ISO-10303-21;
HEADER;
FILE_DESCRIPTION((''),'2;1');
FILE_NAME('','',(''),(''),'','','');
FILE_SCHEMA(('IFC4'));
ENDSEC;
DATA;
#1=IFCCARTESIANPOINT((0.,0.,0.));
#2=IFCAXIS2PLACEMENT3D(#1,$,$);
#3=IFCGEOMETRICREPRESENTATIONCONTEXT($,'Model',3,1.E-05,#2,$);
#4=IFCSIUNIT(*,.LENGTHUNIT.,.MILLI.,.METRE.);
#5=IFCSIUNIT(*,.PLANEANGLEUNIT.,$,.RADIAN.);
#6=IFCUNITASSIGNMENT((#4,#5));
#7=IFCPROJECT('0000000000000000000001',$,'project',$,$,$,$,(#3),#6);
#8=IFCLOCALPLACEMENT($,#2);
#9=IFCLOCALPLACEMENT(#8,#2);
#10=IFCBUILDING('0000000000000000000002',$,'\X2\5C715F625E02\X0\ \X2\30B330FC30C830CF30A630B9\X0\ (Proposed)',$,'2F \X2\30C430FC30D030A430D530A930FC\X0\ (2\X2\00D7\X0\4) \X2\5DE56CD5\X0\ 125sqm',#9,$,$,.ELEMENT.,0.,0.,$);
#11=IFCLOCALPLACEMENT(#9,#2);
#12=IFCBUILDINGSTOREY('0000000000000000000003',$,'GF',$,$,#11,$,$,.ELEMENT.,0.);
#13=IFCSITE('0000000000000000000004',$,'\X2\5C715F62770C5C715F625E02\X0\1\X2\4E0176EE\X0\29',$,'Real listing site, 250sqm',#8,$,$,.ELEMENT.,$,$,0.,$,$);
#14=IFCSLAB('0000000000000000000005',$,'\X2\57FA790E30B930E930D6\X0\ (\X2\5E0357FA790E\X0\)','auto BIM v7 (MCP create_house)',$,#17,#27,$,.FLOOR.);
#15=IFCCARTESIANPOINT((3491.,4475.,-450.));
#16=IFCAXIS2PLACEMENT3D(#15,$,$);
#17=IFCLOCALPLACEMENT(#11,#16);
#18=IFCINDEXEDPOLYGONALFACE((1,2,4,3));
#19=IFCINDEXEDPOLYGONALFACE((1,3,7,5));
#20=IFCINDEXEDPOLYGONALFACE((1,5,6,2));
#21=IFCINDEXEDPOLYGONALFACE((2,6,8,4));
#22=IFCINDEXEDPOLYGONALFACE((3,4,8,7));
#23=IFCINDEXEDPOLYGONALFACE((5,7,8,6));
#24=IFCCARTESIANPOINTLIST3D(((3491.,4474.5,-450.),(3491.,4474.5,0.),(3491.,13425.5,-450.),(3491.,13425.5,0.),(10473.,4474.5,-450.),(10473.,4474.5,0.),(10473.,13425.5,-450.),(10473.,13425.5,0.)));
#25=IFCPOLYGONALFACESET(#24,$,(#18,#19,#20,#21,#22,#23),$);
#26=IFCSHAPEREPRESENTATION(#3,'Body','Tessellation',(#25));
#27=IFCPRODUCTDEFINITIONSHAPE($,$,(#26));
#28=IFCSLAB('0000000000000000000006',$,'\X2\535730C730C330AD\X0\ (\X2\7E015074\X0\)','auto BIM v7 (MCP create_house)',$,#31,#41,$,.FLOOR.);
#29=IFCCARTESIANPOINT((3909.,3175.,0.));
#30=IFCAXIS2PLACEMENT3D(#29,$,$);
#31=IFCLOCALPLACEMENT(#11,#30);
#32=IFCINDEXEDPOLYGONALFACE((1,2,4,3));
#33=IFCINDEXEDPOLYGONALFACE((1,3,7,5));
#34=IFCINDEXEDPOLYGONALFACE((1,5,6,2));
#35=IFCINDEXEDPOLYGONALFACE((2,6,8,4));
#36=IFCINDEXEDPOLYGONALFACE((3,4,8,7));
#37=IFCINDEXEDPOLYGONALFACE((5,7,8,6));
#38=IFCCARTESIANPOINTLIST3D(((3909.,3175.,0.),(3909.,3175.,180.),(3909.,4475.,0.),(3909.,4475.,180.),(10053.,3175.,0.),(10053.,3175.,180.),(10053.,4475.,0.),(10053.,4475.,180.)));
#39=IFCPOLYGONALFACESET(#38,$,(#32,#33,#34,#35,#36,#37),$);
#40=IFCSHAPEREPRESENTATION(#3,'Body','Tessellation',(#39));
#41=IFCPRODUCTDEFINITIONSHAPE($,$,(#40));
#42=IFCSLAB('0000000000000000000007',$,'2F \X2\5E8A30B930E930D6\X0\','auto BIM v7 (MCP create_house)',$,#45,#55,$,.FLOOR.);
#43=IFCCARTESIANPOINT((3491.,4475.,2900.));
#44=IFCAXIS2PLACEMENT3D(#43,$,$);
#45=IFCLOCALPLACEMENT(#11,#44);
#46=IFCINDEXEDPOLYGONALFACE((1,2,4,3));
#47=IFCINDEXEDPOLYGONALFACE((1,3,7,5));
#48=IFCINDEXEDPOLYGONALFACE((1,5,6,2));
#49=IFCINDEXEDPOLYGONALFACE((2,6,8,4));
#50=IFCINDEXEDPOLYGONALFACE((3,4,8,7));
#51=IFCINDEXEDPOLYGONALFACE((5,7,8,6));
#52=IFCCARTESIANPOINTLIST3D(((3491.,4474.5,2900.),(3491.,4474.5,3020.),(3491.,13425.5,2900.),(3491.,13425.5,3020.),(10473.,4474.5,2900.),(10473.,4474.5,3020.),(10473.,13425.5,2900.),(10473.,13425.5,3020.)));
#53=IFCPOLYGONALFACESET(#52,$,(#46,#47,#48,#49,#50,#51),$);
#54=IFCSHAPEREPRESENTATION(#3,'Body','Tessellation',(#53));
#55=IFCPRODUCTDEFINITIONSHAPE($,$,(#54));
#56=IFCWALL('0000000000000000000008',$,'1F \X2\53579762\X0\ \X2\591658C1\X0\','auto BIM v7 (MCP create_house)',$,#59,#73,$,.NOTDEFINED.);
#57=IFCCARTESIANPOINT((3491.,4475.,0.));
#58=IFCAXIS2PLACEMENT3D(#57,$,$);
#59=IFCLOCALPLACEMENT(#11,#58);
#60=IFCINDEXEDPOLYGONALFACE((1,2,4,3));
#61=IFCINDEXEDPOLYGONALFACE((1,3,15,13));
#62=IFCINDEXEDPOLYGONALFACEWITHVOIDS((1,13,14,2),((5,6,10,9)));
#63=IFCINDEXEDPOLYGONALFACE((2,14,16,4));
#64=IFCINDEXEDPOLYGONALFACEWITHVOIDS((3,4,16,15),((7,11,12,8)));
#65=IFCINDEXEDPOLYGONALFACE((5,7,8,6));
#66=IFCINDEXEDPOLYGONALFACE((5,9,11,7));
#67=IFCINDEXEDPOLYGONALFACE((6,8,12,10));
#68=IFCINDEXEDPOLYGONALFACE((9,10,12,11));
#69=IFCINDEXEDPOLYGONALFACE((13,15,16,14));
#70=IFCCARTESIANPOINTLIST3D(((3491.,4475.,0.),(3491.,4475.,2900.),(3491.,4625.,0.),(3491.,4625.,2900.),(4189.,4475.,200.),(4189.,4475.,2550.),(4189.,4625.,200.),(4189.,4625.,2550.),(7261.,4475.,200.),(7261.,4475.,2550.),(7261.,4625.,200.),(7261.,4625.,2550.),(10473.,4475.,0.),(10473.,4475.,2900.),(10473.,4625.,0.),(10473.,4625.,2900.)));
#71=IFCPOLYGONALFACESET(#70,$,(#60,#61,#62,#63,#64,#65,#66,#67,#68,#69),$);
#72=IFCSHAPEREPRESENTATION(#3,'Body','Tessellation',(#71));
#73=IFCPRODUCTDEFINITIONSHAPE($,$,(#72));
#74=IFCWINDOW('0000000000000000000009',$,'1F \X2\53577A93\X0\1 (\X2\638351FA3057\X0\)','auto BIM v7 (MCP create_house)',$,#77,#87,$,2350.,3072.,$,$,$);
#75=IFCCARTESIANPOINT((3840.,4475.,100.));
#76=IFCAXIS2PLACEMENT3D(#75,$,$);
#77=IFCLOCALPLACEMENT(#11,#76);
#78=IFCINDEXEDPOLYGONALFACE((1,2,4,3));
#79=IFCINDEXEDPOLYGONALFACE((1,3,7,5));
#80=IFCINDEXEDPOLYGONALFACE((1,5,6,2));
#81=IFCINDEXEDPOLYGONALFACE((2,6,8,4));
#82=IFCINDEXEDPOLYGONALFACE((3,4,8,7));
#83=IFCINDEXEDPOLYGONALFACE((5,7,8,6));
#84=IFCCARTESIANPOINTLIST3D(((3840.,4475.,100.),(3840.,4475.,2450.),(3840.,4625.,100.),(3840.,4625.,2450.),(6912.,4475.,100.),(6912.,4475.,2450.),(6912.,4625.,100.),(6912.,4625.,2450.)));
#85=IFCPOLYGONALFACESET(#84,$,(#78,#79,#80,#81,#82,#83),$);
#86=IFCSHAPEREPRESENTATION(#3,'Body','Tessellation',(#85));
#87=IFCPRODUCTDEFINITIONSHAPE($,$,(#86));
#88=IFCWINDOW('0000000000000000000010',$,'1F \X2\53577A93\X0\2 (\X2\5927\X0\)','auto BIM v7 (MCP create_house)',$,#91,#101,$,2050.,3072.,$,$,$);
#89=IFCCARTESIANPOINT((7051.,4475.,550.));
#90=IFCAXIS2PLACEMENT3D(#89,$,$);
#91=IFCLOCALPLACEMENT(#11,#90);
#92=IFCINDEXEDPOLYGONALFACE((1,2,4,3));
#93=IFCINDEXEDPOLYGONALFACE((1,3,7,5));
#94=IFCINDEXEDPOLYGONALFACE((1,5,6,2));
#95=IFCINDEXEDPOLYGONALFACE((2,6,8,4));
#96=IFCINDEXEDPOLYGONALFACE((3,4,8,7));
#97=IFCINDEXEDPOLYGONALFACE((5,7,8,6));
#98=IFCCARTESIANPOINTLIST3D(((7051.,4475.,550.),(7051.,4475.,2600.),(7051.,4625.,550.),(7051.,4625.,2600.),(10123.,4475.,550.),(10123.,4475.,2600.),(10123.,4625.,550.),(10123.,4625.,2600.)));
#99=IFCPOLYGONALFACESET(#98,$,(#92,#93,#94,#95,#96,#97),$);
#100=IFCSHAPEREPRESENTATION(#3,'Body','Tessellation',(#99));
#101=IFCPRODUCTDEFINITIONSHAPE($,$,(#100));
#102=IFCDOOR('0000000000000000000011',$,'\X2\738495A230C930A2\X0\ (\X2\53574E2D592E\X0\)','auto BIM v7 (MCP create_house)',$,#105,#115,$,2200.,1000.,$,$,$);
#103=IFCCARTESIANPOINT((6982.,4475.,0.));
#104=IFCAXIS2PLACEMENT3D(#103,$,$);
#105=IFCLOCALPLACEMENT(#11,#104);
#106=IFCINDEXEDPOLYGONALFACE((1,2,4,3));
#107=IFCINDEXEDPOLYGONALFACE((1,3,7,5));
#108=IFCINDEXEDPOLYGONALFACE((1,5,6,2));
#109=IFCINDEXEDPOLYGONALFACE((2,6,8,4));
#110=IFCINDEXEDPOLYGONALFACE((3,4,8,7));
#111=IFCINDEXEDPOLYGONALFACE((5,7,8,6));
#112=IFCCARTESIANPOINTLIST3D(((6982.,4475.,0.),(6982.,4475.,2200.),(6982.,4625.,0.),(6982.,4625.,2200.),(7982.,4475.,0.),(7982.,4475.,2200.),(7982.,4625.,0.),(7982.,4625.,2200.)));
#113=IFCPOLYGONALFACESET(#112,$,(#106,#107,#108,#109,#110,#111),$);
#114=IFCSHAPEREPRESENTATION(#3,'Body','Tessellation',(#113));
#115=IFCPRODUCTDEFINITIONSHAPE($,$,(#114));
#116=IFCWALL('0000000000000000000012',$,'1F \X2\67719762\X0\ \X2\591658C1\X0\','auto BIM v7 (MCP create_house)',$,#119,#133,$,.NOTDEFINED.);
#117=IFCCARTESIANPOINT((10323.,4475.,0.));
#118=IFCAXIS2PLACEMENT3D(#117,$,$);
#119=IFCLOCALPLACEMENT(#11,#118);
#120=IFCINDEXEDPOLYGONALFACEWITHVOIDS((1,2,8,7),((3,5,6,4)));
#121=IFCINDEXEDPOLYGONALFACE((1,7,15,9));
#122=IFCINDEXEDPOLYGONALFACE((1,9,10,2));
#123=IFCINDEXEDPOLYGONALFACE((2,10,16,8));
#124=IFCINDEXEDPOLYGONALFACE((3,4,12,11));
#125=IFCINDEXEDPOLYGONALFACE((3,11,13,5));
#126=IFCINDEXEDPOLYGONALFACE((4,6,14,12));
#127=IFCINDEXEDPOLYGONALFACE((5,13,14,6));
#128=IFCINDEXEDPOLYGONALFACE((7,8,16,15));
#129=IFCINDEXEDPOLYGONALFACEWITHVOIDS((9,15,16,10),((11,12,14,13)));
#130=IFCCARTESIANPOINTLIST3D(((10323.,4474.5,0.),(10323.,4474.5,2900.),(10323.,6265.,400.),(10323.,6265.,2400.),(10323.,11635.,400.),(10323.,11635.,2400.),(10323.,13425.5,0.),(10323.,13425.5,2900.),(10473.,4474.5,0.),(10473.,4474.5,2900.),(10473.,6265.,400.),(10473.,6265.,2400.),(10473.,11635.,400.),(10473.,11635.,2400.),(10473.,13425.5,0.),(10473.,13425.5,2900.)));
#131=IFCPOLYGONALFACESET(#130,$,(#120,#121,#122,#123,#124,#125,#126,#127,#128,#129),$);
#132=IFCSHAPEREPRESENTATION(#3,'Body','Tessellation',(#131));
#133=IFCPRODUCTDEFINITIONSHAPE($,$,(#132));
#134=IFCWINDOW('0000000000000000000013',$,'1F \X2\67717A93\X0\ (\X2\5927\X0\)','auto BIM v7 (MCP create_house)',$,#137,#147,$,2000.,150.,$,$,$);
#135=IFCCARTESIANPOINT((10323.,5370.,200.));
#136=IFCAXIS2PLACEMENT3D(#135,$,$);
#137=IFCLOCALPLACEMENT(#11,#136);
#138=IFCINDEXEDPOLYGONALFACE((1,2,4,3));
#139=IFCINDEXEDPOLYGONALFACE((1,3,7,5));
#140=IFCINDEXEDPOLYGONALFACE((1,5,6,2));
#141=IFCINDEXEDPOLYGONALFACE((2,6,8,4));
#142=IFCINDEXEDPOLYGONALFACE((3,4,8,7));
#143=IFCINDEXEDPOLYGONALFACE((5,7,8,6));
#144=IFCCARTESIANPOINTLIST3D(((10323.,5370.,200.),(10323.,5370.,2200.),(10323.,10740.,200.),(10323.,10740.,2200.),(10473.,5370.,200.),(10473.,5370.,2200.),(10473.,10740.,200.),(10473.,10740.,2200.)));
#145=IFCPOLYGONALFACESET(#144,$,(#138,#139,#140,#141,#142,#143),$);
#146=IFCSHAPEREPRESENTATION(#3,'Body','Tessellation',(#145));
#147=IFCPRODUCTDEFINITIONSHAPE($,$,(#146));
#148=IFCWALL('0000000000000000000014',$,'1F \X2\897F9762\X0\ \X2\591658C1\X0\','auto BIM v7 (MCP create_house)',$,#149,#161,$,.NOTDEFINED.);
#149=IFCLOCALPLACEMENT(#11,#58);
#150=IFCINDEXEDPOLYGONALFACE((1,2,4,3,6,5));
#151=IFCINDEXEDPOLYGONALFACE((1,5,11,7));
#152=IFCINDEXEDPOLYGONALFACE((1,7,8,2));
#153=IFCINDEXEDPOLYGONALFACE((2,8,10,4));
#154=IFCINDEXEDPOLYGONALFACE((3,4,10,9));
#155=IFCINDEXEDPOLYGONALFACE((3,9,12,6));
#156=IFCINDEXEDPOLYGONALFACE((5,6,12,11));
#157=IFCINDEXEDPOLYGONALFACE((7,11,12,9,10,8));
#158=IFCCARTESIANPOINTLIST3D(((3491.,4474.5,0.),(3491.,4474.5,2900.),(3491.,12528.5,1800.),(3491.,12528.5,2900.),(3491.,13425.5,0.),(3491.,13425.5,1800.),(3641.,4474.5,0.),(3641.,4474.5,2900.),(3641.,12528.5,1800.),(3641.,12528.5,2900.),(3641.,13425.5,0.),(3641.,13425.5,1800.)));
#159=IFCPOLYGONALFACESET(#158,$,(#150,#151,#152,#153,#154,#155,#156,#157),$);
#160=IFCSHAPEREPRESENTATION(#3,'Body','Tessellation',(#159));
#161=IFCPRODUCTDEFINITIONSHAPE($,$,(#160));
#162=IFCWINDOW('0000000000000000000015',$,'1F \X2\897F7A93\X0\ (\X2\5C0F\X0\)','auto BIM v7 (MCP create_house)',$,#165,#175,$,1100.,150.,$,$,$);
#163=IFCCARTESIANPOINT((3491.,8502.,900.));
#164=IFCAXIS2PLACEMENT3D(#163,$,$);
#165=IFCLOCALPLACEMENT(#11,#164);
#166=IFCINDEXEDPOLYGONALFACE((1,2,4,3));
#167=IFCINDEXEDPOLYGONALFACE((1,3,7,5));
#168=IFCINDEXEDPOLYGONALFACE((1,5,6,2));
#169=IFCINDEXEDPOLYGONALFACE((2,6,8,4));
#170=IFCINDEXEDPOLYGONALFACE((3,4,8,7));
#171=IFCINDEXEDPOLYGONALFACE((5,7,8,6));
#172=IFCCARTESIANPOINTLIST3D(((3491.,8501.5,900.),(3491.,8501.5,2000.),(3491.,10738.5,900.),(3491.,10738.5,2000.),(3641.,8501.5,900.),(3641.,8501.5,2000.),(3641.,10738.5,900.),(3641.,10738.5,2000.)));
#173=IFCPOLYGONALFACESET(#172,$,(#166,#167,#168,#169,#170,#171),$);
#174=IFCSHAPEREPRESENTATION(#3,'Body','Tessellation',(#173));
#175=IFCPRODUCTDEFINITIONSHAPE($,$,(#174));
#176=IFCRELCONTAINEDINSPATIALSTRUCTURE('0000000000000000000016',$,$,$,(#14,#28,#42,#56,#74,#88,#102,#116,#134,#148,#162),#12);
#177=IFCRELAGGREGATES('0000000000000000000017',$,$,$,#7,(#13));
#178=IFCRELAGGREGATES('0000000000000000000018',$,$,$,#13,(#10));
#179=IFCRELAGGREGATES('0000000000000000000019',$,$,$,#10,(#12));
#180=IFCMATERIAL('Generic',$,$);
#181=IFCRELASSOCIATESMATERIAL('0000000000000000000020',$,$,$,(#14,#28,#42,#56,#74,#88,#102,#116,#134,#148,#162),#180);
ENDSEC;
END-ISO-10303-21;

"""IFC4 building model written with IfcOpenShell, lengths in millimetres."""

from ifc_helpers import new_model, si_unit, frame, frame_2d, origin, place, context, project, spatial, rectangle, extrude, material, element, fill, save


model = new_model("IFC4")

# Units and contexts
model_context = context("Model", 3, precision=1e-05, world=origin())
ifc_project = project(units=[si_unit("LENGTHUNIT", "METRE", prefix="MILLI"), si_unit("PLANEANGLEUNIT", "RADIAN")], contexts=[model_context])

# Site, building, storey
site_placement = place(None, origin())
site = spatial("IfcSite", under=ifc_project, at=site_placement, Name="山形県山形市1丁目29", ObjectType="Real listing site, 250sqm", CompositionType="ELEMENT", RefElevation=0.0)
building_placement = place(site_placement, origin())
building = spatial("IfcBuilding", under=site, at=building_placement, Name="山形市 コートハウス (Proposed)", ObjectType="2F ツーバイフォー (2×4) 工法 125sqm", CompositionType="ELEMENT", ElevationOfRefHeight=0.0, ElevationOfTerrain=0.0)
storey_placement = place(building_placement, origin())
storey = spatial("IfcBuildingStorey", under=building, at=storey_placement, Name="GF", CompositionType="ELEMENT", Elevation=0.0)

# Slabs
ifc_material = material(Name="Generic")
slab_1_placement = place(storey_placement, frame((3491.0, 4475.0, -450.0)))
element("IfcSlab", 1, at=slab_1_placement, inside=storey, material=ifc_material, Name="基礎スラブ (布基礎)", Description="auto BIM v7 (MCP create_house)", PredefinedType="FLOOR", context=model_context, shape_type="SweptSolid", body=[
    extrude(rectangle(XDim=6982.0, YDim=8951.0, at=frame_2d((3491.0, 4475.0))), frame((3491.0, 4475.0, -450.0)), (0.0, 0.0, 1.0), 450.0),
])
slab_2_placement = place(storey_placement, frame((3909.0, 3175.0, 0.0)))
element("IfcSlab", 2, at=slab_2_placement, inside=storey, material=ifc_material, Name="南デッキ (縁側)", Description="auto BIM v7 (MCP create_house)", PredefinedType="FLOOR", context=model_context, shape_type="SweptSolid", body=[
    extrude(rectangle(XDim=6144.0, YDim=1300.0, at=frame_2d((3072.0, 650.0))), frame((3909.0, 3175.0, 0.0)), (0.0, 0.0, 1.0), 180.0),
])
slab_3_placement = place(storey_placement, frame((3491.0, 4475.0, 2900.0)))
element("IfcSlab", 3, at=slab_3_placement, inside=storey, material=ifc_material, Name="2F 床スラブ", Description="auto BIM v7 (MCP create_house)", PredefinedType="FLOOR", context=model_context, shape_type="SweptSolid", body=[
    extrude(rectangle(XDim=6982.0, YDim=8951.0, at=frame_2d((3491.0, 4475.0))), frame((3491.0, 4475.0, 2900.0)), (0.0, 0.0, 1.0), 120.0),
])

# Wall, openings, windows, door
wall_1_placement = place(storey_placement, frame((3491.0, 4475.0, 0.0)))
wall_1 = element("IfcWall", 4, at=wall_1_placement, inside=storey, material=ifc_material, Name="1F 南面 外壁", Description="auto BIM v7 (MCP create_house)", PredefinedType="NOTDEFINED", context=model_context, shape_type="SweptSolid", body=[
    extrude(rectangle(XDim=6982.0, YDim=150.0, at=frame_2d((3491.0, 75.0))), frame((3491.0, 4475.0, 0.0)), (0.0, 0.0, 1.0), 2900.0),
])
opening_1_placement = place(storey_placement, frame((3840.0, 4475.0, 100.0)))
opening_1 = element("IfcOpeningElement", 5, at=opening_1_placement, cuts=wall_1, PredefinedType="NOTDEFINED", context=model_context, shape_type="SweptSolid", body=[
    extrude(rectangle(XDim=3072.0, YDim=150.0, at=frame_2d((1536.0, 75.0))), frame((3840.0, 4475.0, 100.0)), (0.0, 0.0, 1.0), 2350.0),
])
opening_2_placement = place(storey_placement, frame((7051.0, 4475.0, 550.0)))
opening_2 = element("IfcOpeningElement", 6, at=opening_2_placement, cuts=wall_1, PredefinedType="NOTDEFINED", context=model_context, shape_type="SweptSolid", body=[
    extrude(rectangle(XDim=3072.0, YDim=150.0, at=frame_2d((1536.0, 75.0))), frame((7051.0, 4475.0, 550.0)), (0.0, 0.0, 1.0), 2050.0),
])
opening_3_placement = place(storey_placement, frame((6982.0, 4475.0, 0.0)))
opening_3 = element("IfcOpeningElement", 7, at=opening_3_placement, cuts=wall_1, PredefinedType="NOTDEFINED", context=model_context, shape_type="SweptSolid", body=[
    extrude(rectangle(XDim=1000.0, YDim=150.0, at=frame_2d((500.0, 75.0))), frame((6982.0, 4475.0, 0.0)), (0.0, 0.0, 1.0), 2200.0),
])
window_1_placement = place(storey_placement, frame((3840.0, 4475.0, 100.0)))
window_1 = element("IfcWindow", 8, at=window_1_placement, inside=storey, material=ifc_material, Name="1F 南窓1 (掃出し)", Description="auto BIM v7 (MCP create_house)", OverallHeight=2350.0, OverallWidth=3072.0, context=model_context, shape_type="SweptSolid", body=[
    extrude(rectangle(XDim=3072.0, YDim=150.0, at=frame_2d((1536.0, 75.0))), frame((3840.0, 4475.0, 100.0)), (0.0, 0.0, 1.0), 2350.0),
])
fill(opening_1, window_1)
window_2_placement = place(storey_placement, frame((7051.0, 4475.0, 550.0)))
window_2 = element("IfcWindow", 9, at=window_2_placement, inside=storey, material=ifc_material, Name="1F 南窓2 (大)", Description="auto BIM v7 (MCP create_house)", OverallHeight=2050.0, OverallWidth=3072.0, context=model_context, shape_type="SweptSolid", body=[
    extrude(rectangle(XDim=3072.0, YDim=150.0, at=frame_2d((1536.0, 75.0))), frame((7051.0, 4475.0, 550.0)), (0.0, 0.0, 1.0), 2050.0),
])
fill(opening_2, window_2)
door_placement = place(storey_placement, frame((6982.0, 4475.0, 0.0)))
door = element("IfcDoor", 10, at=door_placement, inside=storey, material=ifc_material, Name="玄関ドア (南中央)", Description="auto BIM v7 (MCP create_house)", OverallHeight=2200.0, OverallWidth=1000.0, context=model_context, shape_type="SweptSolid", body=[
    extrude(rectangle(XDim=1000.0, YDim=150.0, at=frame_2d((500.0, 75.0))), frame((6982.0, 4475.0, 0.0)), (0.0, 0.0, 1.0), 2200.0),
])
fill(opening_3, door)

# Walls, openings, windows
wall_2_placement = place(storey_placement, frame((10323.0, 4475.0, 0.0)))
wall_2 = element("IfcWall", 11, at=wall_2_placement, inside=storey, material=ifc_material, Name="1F 東面 外壁", Description="auto BIM v7 (MCP create_house)", PredefinedType="NOTDEFINED", context=model_context, shape_type="SweptSolid", body=[
    extrude(rectangle(XDim=150.0, YDim=8951.0, at=frame_2d((75.0, 4475.0))), frame((10323.0, 4475.0, 0.0)), (0.0, 0.0, 1.0), 2900.0),
])
opening_4_placement = place(storey_placement, frame((10323.0, 5370.0, 200.0)))
opening_4 = element("IfcOpeningElement", 12, at=opening_4_placement, cuts=wall_2, PredefinedType="NOTDEFINED", context=model_context, shape_type="SweptSolid", body=[
    extrude(rectangle(XDim=150.0, YDim=5370.0, at=frame_2d((75.0, 2685.0))), frame((10323.0, 5370.0, 200.0)), (0.0, 0.0, 1.0), 2000.0),
])
window_3_placement = place(storey_placement, frame((10323.0, 5370.0, 200.0)))
window_3 = element("IfcWindow", 13, at=window_3_placement, inside=storey, material=ifc_material, Name="1F 東窓 (大)", Description="auto BIM v7 (MCP create_house)", OverallHeight=2000.0, OverallWidth=150.0, context=model_context, shape_type="SweptSolid", body=[
    extrude(rectangle(XDim=150.0, YDim=5370.0, at=frame_2d((75.0, 2685.0))), frame((10323.0, 5370.0, 200.0)), (0.0, 0.0, 1.0), 2000.0),
])
fill(opening_4, window_3)
wall_3_placement = place(storey_placement, frame((3491.0, 4475.0, 0.0)))
wall_3 = element("IfcWall", 14, at=wall_3_placement, inside=storey, material=ifc_material, Name="1F 西面 外壁", Description="auto BIM v7 (MCP create_house)", PredefinedType="NOTDEFINED", context=model_context, shape_type="SweptSolid", body=[
    extrude(rectangle(XDim=150.0, YDim=8951.0, at=frame_2d((75.0, 4475.0))), frame((3491.0, 4475.0, 0.0)), (0.0, 0.0, 1.0), 2900.0),
])
opening_5_placement = place(storey_placement, frame((3491.0, 8502.0, 900.0)))
opening_5 = element("IfcOpeningElement", 15, at=opening_5_placement, cuts=wall_3, PredefinedType="NOTDEFINED", context=model_context, shape_type="SweptSolid", body=[
    extrude(rectangle(XDim=150.0, YDim=2237.0, at=frame_2d((75.0, 1118.0))), frame((3491.0, 8502.0, 900.0)), (0.0, 0.0, 1.0), 1100.0),
])
window_4_placement = place(storey_placement, frame((3491.0, 8502.0, 900.0)))
window_4 = element("IfcWindow", 16, at=window_4_placement, inside=storey, material=ifc_material, Name="1F 西窓 (小)", Description="auto BIM v7 (MCP create_house)", OverallHeight=1100.0, OverallWidth=150.0, context=model_context, shape_type="SweptSolid", body=[
    extrude(rectangle(XDim=150.0, YDim=2237.0, at=frame_2d((75.0, 1118.0))), frame((3491.0, 8502.0, 900.0)), (0.0, 0.0, 1.0), 1100.0),
])
fill(opening_5, window_4)

save(model, "model.ifc")
